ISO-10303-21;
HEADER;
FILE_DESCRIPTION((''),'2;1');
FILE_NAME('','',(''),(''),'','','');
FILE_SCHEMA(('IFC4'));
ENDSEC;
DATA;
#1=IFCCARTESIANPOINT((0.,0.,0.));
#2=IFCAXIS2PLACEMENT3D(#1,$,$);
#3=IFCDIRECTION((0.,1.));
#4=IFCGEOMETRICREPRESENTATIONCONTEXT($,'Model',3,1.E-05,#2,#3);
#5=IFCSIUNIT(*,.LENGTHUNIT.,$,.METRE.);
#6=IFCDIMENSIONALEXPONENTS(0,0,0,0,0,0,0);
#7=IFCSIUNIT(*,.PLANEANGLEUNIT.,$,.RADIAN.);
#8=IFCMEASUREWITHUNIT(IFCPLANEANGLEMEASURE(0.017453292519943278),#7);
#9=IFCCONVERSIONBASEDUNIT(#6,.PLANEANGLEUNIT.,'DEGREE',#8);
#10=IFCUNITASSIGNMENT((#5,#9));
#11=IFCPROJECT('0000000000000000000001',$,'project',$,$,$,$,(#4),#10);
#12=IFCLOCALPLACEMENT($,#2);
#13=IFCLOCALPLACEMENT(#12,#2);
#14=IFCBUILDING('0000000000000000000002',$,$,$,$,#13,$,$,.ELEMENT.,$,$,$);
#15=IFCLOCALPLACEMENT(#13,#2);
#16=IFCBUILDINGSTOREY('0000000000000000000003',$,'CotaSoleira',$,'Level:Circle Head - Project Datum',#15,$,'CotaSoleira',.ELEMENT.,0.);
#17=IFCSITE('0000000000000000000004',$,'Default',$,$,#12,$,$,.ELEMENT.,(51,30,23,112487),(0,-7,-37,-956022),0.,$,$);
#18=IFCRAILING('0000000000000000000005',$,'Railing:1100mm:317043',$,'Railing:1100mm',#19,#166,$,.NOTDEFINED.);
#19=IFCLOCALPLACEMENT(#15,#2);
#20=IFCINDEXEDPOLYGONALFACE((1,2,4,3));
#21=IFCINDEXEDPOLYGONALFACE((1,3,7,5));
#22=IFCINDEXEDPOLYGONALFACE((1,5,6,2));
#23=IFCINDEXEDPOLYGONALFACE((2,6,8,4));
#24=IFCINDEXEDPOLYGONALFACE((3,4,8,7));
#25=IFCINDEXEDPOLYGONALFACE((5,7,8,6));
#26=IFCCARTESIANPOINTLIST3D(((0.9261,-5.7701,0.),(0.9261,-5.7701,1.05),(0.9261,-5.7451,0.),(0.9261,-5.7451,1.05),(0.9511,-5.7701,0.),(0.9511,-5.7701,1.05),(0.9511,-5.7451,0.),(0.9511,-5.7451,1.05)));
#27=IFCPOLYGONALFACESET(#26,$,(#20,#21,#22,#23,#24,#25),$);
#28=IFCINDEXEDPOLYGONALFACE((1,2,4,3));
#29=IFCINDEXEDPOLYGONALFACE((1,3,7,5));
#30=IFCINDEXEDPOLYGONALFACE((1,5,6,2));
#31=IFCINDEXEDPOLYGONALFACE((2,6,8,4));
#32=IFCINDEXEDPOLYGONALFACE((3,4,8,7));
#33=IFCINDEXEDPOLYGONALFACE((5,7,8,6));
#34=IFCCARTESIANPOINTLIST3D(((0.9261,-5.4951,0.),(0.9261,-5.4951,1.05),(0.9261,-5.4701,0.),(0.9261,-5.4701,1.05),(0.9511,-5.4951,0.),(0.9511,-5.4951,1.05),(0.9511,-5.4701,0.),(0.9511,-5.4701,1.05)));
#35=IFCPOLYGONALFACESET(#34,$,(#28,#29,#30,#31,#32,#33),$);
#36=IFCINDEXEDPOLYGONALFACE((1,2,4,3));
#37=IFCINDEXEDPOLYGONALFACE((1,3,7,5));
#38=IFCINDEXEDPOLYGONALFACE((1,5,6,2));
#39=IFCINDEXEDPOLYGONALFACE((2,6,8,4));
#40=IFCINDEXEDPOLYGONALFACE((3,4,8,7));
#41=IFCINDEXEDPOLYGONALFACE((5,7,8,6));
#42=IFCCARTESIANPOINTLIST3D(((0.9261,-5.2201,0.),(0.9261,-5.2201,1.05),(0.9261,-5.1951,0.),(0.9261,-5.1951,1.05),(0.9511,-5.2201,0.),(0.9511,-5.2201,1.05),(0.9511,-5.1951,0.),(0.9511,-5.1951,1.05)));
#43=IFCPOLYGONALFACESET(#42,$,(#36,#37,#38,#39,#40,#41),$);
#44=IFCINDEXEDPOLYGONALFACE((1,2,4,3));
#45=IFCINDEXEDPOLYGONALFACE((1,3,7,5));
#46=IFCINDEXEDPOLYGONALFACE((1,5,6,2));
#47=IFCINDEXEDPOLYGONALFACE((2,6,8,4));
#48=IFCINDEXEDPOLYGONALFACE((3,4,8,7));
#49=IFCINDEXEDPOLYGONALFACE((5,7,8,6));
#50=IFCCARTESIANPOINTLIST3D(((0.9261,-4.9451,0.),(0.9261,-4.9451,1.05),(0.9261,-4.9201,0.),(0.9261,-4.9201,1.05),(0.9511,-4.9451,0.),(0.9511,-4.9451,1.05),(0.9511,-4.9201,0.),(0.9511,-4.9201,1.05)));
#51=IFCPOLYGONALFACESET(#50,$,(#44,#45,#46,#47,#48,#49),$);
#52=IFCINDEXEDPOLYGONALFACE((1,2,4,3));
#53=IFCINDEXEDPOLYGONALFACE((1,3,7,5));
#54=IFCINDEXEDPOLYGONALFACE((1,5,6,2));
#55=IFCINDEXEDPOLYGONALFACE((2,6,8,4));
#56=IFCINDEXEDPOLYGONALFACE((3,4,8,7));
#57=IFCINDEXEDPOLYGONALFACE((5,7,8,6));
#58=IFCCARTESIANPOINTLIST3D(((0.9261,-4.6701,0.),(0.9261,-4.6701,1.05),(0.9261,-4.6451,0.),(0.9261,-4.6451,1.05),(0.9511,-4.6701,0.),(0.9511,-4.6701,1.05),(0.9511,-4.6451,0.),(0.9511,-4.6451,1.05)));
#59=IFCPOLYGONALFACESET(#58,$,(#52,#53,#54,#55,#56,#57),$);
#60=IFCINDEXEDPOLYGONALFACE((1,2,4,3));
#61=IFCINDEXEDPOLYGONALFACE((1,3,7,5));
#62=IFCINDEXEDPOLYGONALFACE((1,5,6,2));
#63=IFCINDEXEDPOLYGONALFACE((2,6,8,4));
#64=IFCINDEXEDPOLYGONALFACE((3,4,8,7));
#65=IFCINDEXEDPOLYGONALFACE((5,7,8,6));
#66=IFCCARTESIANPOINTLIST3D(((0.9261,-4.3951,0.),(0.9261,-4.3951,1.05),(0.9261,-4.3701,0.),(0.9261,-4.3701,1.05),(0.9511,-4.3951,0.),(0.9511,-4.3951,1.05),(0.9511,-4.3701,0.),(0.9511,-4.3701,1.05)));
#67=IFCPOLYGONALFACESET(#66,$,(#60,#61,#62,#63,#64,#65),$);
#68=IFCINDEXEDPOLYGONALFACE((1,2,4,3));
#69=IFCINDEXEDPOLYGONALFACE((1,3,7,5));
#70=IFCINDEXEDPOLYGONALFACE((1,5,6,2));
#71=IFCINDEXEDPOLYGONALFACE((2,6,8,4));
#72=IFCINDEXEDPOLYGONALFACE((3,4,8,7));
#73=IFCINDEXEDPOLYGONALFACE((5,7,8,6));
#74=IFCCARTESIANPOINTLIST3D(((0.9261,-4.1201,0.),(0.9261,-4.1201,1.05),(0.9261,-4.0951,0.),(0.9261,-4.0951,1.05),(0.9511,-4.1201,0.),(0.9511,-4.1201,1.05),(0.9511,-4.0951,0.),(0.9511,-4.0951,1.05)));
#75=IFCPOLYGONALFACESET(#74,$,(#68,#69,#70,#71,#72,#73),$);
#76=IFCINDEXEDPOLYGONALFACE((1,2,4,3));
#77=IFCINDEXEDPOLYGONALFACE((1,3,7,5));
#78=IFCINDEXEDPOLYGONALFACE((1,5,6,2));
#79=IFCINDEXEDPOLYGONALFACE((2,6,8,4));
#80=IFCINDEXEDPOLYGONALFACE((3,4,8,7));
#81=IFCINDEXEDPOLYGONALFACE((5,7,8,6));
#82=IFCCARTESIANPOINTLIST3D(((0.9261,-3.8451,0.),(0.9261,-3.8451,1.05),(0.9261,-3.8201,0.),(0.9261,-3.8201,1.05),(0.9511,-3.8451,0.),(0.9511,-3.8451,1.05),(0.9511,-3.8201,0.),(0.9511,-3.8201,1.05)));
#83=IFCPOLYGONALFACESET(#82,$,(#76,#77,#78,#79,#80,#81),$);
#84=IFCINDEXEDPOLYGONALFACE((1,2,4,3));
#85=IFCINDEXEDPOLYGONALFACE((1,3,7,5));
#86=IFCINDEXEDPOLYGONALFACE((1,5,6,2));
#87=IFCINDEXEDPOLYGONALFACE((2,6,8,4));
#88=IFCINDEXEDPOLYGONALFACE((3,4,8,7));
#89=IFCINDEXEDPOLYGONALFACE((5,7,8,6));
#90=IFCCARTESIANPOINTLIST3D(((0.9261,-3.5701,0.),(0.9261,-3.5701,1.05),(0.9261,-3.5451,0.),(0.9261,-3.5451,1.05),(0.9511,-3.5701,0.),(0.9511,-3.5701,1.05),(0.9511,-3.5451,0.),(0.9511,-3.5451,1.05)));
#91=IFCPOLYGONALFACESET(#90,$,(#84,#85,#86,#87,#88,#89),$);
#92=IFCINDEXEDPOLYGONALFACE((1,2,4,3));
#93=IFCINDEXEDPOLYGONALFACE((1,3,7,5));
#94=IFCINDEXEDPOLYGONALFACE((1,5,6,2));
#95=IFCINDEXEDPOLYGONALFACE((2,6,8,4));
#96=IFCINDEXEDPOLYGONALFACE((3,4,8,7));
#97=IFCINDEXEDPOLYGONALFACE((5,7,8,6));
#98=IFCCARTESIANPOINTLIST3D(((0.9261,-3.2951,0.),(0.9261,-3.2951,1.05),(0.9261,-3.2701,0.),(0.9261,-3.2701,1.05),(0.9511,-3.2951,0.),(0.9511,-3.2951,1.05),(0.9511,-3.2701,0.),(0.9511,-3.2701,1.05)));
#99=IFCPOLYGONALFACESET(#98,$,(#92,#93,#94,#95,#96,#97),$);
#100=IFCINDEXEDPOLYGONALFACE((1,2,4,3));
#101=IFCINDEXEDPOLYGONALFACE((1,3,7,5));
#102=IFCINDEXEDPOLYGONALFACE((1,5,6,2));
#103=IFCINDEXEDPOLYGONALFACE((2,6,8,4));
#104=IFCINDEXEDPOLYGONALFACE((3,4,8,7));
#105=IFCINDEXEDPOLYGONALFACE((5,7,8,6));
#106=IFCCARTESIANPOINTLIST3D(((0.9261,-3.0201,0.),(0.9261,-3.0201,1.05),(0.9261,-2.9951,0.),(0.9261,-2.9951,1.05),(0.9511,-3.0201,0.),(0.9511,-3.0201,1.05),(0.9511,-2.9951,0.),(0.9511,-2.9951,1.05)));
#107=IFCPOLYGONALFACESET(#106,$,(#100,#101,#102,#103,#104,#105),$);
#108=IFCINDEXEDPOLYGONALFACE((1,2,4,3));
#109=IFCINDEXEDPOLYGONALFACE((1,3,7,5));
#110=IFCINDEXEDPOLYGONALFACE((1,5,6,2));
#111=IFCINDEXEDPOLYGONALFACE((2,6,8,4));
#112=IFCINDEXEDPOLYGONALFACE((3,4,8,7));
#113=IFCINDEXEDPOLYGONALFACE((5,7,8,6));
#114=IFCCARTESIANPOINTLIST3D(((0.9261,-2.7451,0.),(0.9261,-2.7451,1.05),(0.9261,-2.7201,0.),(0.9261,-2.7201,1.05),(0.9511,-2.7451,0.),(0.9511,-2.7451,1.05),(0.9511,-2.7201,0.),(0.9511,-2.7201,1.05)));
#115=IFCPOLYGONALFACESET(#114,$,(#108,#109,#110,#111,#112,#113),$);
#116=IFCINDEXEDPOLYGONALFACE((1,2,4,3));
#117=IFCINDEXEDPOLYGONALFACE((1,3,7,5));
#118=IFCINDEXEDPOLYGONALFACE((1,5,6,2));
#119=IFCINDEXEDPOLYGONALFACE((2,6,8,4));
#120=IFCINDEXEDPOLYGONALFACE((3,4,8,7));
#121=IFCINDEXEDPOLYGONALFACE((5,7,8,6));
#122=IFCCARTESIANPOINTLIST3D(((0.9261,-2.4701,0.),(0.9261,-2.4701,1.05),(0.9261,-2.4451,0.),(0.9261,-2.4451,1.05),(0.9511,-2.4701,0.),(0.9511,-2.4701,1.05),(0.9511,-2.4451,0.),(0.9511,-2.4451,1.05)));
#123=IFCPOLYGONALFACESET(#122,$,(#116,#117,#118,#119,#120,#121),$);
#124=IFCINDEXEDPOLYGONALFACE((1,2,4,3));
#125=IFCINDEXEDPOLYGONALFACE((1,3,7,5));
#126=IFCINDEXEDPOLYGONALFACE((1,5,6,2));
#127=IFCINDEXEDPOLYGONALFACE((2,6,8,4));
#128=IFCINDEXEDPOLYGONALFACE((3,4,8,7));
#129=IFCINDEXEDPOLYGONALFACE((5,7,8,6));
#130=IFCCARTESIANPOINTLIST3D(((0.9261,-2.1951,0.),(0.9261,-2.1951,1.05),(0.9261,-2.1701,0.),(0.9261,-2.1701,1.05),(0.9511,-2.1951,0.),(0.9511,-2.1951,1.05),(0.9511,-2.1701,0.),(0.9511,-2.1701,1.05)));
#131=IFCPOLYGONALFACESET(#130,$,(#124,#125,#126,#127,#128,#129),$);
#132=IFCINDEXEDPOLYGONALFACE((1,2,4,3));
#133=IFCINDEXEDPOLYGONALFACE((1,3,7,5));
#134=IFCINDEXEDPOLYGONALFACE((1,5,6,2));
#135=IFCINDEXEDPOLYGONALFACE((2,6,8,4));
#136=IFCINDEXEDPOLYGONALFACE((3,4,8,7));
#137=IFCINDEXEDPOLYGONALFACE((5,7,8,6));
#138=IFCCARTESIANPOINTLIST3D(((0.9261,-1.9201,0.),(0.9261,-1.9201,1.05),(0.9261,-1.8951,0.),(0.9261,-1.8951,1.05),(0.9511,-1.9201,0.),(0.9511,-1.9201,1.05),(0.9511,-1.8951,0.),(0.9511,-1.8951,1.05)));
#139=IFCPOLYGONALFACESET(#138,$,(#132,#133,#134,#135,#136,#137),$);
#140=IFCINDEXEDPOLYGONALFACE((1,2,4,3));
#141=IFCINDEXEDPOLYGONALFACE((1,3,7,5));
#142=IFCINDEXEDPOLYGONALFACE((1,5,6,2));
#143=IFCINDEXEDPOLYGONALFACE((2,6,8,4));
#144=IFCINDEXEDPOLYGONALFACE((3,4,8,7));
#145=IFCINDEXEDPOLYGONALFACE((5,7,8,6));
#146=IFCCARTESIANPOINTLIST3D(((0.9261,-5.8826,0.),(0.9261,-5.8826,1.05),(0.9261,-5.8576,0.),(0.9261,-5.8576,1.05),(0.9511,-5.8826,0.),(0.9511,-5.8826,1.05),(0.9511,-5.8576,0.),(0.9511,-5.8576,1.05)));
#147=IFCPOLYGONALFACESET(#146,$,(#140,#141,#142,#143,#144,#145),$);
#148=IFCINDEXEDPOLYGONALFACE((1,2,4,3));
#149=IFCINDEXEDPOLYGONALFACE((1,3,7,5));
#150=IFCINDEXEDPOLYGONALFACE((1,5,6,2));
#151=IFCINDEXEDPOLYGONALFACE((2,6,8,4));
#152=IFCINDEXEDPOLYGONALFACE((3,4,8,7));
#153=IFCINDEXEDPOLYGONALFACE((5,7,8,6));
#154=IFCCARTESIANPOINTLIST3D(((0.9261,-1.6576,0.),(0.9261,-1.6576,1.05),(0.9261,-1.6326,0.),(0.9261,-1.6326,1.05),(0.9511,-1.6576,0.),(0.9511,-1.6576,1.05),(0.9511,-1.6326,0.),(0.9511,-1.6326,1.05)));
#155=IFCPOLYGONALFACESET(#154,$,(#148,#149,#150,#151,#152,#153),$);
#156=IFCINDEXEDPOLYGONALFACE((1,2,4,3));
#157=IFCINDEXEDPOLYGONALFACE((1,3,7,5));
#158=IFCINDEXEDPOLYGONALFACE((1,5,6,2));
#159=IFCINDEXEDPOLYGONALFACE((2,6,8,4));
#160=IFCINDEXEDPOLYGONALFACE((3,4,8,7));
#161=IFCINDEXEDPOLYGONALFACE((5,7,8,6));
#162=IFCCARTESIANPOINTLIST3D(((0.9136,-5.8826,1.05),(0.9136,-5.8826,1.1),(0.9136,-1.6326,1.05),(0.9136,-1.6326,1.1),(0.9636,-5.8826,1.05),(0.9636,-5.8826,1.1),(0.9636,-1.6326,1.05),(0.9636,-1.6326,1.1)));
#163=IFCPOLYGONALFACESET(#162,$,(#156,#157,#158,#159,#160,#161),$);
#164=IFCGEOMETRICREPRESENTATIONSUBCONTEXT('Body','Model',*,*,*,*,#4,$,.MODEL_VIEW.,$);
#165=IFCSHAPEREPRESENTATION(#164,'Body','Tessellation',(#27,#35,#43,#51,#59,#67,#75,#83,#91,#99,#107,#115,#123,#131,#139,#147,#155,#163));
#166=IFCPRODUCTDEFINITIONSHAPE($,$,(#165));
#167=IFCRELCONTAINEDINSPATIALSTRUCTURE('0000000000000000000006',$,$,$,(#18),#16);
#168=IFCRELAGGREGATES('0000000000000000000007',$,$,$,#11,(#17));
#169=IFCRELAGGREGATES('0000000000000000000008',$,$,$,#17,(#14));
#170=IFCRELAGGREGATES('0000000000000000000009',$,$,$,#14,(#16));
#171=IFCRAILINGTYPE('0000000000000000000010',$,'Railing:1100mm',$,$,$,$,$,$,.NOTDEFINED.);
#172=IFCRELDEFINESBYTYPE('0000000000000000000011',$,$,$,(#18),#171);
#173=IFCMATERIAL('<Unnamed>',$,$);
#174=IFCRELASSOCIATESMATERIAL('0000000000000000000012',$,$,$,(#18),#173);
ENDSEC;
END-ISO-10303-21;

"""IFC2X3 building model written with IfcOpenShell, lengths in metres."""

from ifc_helpers import new_model, entity, si_unit, converted_unit, direction, frame, frame_2d, origin, origin_2d_with_axis, place, context, subcontext, project, spatial, rectangle, extrude, material, type_object, element, save


model = new_model("IFC2X3")

# Units and contexts
model_context = context("Model", 3, precision=1e-05, world=origin(), true_north=direction((0.0, 1.0)))
body_context = subcontext(model_context, "Body", "Model", "MODEL_VIEW")
ifc_project = project(units=[si_unit("LENGTHUNIT", "METRE"), converted_unit("PLANEANGLEUNIT", "DEGREE", entity("IfcPlaneAngleMeasure", 0.017453292519943278), si_unit("PLANEANGLEUNIT", "RADIAN"), dimensions=[0, 0, 0, 0, 0, 0, 0])], contexts=[model_context])

# Site, building, storey
site_placement = place(None, origin())
site = spatial("IfcSite", under=ifc_project, at=site_placement, Name="Default", CompositionType="ELEMENT", RefLatitude=(51, 30, 23, 112487), RefLongitude=(0, -7, -37, -956022), RefElevation=0.0)
building_placement = place(site_placement, origin())
building = spatial("IfcBuilding", under=site, at=building_placement, CompositionType="ELEMENT")
storey_placement = place(building_placement, origin())
storey = spatial("IfcBuildingStorey", under=building, at=storey_placement, Name="CotaSoleira", ObjectType="Level:Circle Head - Project Datum", LongName="CotaSoleira", CompositionType="ELEMENT", Elevation=0.0)

# Shared definitions
ifc_material_1 = material(Name="<Unnamed>")

# Railing
railing_type = type_object("IfcRailingType", Name="Railing:1100mm", PredefinedType="NOTDEFINED")
railing_1_placement = place(storey_placement, origin())
element("IfcRailing", 1, at=railing_1_placement, inside=storey, type_object=railing_type, material=ifc_material_1, Name="Railing:1100mm:317043", ObjectType="Railing:1100mm", PredefinedType="NOTDEFINED", context=body_context, shape_type="SweptSolid", body=[
    extrude(rectangle(XDim=0.025, YDim=0.025, at=origin_2d_with_axis()), frame((0.9386, -5.7576, 0.0), z_axis=(0.0, 0.0, 1.0), x_axis=(0.0, -1.0, 0.0)), (0.0, 0.0, 1.0), 1.05),
    extrude(rectangle(XDim=0.025, YDim=0.025, at=origin_2d_with_axis()), frame((0.9386, -5.4826, 0.0), z_axis=(0.0, 0.0, 1.0), x_axis=(0.0, -1.0, 0.0)), (0.0, 0.0, 1.0), 1.05),
    extrude(rectangle(XDim=0.025, YDim=0.025, at=frame_2d((0.0, 0.0), x_axis=(1.0, 0.0))), frame((0.9386, -5.2076, 0.0), z_axis=(0.0, 0.0, 1.0), x_axis=(0.0, -1.0, 0.0)), (0.0, 0.0, 1.0), 1.05),
    extrude(rectangle(XDim=0.025, YDim=0.025, at=origin_2d_with_axis()), frame((0.9386, -4.9326, 0.0), z_axis=(0.0, 0.0, 1.0), x_axis=(0.0, -1.0, 0.0)), (0.0, 0.0, 1.0), 1.05),
    extrude(rectangle(XDim=0.025, YDim=0.025, at=frame_2d((0.0, 0.0), x_axis=(1.0, 0.0))), frame((0.9386, -4.6576, 0.0), z_axis=(0.0, 0.0, 1.0), x_axis=(0.0, -1.0, 0.0)), (0.0, 0.0, 1.0), 1.05),
    extrude(rectangle(XDim=0.025, YDim=0.025, at=origin_2d_with_axis()), frame((0.9386, -4.3826, 0.0), z_axis=(0.0, 0.0, 1.0), x_axis=(0.0, -1.0, 0.0)), (0.0, 0.0, 1.0), 1.05),
    extrude(rectangle(XDim=0.025, YDim=0.025, at=origin_2d_with_axis()), frame((0.9386, -4.1076, 0.0), z_axis=(0.0, 0.0, 1.0), x_axis=(0.0, -1.0, 0.0)), (0.0, 0.0, 1.0), 1.05),
    extrude(rectangle(XDim=0.025, YDim=0.025, at=origin_2d_with_axis()), frame((0.9386, -3.8326, 0.0), z_axis=(0.0, 0.0, 1.0), x_axis=(0.0, -1.0, 0.0)), (0.0, 0.0, 1.0), 1.05),
    extrude(rectangle(XDim=0.025, YDim=0.025, at=frame_2d((0.0, 0.0), x_axis=(1.0, 0.0))), frame((0.9386, -3.5576, 0.0), z_axis=(0.0, 0.0, 1.0), x_axis=(0.0, -1.0, 0.0)), (0.0, 0.0, 1.0), 1.05),
    extrude(rectangle(XDim=0.025, YDim=0.025, at=origin_2d_with_axis()), frame((0.9386, -3.2826, 0.0), z_axis=(0.0, 0.0, 1.0), x_axis=(0.0, -1.0, 0.0)), (0.0, 0.0, 1.0), 1.05),
    extrude(rectangle(XDim=0.025, YDim=0.025, at=origin_2d_with_axis()), frame((0.9386, -3.0076, 0.0), z_axis=(0.0, 0.0, 1.0), x_axis=(0.0, -1.0, 0.0)), (0.0, 0.0, 1.0), 1.05),
    extrude(rectangle(XDim=0.025, YDim=0.025, at=origin_2d_with_axis()), frame((0.9386, -2.7326, 0.0), z_axis=(0.0, 0.0, 1.0), x_axis=(0.0, -1.0, 0.0)), (0.0, 0.0, 1.0), 1.05),
    extrude(rectangle(XDim=0.025, YDim=0.025, at=origin_2d_with_axis()), frame((0.9386, -2.4576, 0.0), z_axis=(0.0, 0.0, 1.0), x_axis=(0.0, -1.0, 0.0)), (0.0, 0.0, 1.0), 1.05),
    extrude(rectangle(XDim=0.025, YDim=0.025, at=frame_2d((0.0, 0.0), x_axis=(1.0, 0.0))), frame((0.9386, -2.1826, 0.0), z_axis=(0.0, 0.0, 1.0), x_axis=(0.0, -1.0, 0.0)), (0.0, 0.0, 1.0), 1.05),
    extrude(rectangle(XDim=0.025, YDim=0.025, at=frame_2d((0.0, 0.0), x_axis=(1.0, 0.0))), frame((0.9386, -1.9076, 0.0), z_axis=(0.0, 0.0, 1.0), x_axis=(0.0, -1.0, 0.0)), (0.0, 0.0, 1.0), 1.05),
    extrude(rectangle(XDim=0.025, YDim=0.025, at=frame_2d((0.0, 0.0), x_axis=(1.0, 0.0))), frame((0.9386, -5.8701, 0.0), z_axis=(0.0, 0.0, 1.0), x_axis=(0.0, -1.0, 0.0)), (0.0, 0.0, 1.0), 1.05),
    extrude(rectangle(XDim=0.025, YDim=0.025, at=origin_2d_with_axis()), frame((0.9386, -1.6451, 0.0), z_axis=(0.0, 0.0, 1.0), x_axis=(0.0, -1.0, 0.0)), (0.0, 0.0, 1.0), 1.05),
    extrude(rectangle(XDim=4.25, YDim=0.05, at=frame_2d((0.0, 0.0), x_axis=(1.0, 0.0))), frame((0.9386, -3.7576, 1.05), z_axis=(0.0, 0.0, 1.0), x_axis=(0.0, -1.0, 0.0)), (0.0, 0.0, 1.0), 0.05),
])

save(model, "model.ifc")
